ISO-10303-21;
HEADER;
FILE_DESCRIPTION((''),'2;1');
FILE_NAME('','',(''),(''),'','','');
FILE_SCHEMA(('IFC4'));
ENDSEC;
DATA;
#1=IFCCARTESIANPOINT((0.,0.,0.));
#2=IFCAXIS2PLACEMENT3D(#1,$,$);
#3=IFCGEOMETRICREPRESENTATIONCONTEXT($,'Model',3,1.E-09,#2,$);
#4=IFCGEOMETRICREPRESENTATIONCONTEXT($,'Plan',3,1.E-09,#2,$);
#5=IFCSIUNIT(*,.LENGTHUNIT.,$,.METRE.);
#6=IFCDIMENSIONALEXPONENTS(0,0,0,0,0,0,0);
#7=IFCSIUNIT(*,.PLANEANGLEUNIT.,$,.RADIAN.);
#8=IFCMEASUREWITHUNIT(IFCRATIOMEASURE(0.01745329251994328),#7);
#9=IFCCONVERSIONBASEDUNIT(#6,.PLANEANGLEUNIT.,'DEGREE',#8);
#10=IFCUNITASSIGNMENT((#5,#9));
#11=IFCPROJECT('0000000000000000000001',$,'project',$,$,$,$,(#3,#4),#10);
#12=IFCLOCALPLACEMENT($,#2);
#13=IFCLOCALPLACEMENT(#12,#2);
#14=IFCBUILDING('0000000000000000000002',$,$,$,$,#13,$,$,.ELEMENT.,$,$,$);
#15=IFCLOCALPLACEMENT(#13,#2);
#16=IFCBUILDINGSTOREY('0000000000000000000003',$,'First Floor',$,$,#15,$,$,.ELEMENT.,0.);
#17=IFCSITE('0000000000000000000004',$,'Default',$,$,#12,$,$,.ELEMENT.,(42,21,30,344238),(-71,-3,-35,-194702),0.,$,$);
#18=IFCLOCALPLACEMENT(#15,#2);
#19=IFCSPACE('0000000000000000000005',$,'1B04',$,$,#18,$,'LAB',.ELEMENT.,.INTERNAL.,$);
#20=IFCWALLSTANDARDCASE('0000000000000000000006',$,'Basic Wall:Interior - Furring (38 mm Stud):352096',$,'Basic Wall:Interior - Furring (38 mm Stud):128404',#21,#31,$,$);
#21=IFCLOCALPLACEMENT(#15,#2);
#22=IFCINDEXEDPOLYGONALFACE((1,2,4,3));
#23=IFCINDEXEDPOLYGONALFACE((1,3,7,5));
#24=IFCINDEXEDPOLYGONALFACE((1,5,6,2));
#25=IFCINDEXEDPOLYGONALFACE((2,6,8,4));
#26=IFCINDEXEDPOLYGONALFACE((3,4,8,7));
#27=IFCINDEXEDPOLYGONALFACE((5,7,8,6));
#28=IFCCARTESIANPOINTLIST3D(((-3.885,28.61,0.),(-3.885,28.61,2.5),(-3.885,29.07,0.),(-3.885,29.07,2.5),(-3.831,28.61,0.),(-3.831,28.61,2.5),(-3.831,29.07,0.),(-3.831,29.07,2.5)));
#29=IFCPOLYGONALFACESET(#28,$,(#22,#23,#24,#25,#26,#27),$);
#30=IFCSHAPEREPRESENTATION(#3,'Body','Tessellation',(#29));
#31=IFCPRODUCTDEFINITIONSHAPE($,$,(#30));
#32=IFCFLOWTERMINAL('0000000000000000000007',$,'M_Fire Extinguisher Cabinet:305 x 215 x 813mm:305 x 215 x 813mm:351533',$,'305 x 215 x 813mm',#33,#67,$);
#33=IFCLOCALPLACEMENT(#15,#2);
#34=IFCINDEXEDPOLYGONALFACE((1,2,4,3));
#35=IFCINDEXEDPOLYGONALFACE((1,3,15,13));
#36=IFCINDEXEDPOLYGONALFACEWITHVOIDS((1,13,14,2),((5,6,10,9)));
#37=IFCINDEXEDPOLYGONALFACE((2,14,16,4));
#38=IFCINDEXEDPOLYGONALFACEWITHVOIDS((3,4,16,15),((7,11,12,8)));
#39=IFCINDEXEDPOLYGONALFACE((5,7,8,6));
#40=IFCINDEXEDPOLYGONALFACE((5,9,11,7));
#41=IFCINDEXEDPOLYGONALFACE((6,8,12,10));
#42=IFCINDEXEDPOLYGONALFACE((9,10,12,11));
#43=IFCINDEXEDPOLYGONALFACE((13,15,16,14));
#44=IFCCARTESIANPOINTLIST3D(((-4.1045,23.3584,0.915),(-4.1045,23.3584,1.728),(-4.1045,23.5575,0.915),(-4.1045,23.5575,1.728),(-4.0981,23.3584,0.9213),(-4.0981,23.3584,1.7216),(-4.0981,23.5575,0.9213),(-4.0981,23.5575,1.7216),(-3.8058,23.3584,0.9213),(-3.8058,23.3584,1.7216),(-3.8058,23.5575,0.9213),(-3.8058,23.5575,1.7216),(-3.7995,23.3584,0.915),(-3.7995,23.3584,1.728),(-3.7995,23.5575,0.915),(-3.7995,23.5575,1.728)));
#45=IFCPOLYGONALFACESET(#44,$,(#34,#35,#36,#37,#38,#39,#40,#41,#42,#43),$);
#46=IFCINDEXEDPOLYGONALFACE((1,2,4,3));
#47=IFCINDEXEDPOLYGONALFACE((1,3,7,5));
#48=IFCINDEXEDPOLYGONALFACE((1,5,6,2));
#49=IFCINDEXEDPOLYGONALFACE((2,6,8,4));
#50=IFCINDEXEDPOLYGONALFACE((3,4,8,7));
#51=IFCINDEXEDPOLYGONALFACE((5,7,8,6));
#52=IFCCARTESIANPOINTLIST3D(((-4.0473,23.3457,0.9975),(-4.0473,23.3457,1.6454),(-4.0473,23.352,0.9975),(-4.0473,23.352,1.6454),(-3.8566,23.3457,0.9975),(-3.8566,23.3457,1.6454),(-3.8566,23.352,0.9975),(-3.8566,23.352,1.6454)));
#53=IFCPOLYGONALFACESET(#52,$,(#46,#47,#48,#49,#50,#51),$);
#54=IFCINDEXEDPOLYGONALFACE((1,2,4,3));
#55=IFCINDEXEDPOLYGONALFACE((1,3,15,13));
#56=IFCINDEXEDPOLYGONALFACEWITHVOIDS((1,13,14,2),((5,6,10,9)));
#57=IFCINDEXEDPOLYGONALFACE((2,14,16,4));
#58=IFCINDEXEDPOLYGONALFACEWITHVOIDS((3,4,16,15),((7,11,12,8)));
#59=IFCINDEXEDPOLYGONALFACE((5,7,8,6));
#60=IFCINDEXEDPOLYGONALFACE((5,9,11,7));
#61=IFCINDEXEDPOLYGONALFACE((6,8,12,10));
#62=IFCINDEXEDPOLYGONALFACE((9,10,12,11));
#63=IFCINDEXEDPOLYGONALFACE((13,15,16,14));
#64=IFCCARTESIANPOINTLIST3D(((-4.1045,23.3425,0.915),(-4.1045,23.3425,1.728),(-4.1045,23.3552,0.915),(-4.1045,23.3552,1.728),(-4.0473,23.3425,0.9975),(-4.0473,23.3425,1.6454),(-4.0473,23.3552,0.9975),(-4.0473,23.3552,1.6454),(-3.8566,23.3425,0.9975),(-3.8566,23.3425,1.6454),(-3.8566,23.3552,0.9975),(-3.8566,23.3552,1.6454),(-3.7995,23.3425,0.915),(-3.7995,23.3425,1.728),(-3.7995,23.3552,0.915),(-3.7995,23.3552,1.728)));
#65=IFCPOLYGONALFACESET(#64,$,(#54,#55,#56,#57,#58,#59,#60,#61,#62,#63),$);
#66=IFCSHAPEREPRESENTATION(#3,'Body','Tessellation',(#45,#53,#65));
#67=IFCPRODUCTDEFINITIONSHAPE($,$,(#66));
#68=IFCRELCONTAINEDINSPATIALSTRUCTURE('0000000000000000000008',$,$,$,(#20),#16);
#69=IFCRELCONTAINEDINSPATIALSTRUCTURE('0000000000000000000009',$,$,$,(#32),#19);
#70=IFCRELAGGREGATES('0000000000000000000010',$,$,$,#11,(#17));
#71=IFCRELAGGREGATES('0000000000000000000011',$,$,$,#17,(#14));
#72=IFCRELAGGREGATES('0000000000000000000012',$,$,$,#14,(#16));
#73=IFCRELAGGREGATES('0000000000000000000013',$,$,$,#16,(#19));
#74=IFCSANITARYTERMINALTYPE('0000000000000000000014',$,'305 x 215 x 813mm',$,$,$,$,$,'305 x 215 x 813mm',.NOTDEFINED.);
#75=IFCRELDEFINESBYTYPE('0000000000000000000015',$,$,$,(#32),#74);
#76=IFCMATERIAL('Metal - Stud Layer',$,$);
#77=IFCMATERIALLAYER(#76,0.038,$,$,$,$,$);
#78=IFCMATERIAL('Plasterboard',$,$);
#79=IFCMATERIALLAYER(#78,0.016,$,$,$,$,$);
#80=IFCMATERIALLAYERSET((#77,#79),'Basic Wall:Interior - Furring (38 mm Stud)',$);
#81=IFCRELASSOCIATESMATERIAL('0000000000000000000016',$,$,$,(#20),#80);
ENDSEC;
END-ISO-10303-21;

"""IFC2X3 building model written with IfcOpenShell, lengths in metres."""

from ifc_helpers import new_model, entity, si_unit, converted_unit, frame, frame_2d, origin, origin_2d_with_axis, place, context, project, spatial, rectangle, extrude, source, transform, mapped, material, layer, layer_set, layer_usage, type_object, type_shapes, element, save


model = new_model("IFC2X3")

# Units and contexts
model_context = context("Model", 3, precision=1e-09, world=origin())
plan_context = context("Plan", 3, precision=1e-09, world=origin())
ifc_project = project(units=[si_unit("LENGTHUNIT", "METRE"), converted_unit("PLANEANGLEUNIT", "DEGREE", entity("IfcRatioMeasure", 0.01745329251994328), si_unit("PLANEANGLEUNIT", "RADIAN"), dimensions=[0, 0, 0, 0, 0, 0, 0])], contexts=[model_context, plan_context])

# Site, building, storey
site_placement = place(None, origin())
site = spatial("IfcSite", under=ifc_project, at=site_placement, Name="Default", CompositionType="ELEMENT", RefLatitude=(42, 21, 30, 344238), RefLongitude=(-71, -3, -35, -194702), RefElevation=0.0)
building_placement = place(site_placement, origin())
building = spatial("IfcBuilding", under=site, at=building_placement, CompositionType="ELEMENT")
storey_placement = place(building_placement, origin())
storey = spatial("IfcBuildingStorey", under=building, at=storey_placement, Name="First Floor", CompositionType="ELEMENT", Elevation=0.0)

# Shared definitions
ifc_material_1 = material(Name="Plasterboard")
ifc_material_2 = material(Name="Metal - Stud Layer")

# Shared definitions
ifc_layer_1 = layer(ifc_material_2, 0.038)
ifc_layer_2 = layer(ifc_material_1, 0.016)
ifc_layer_set_1 = layer_set([ifc_layer_1, ifc_layer_2], Name="Basic Wall:Interior - Furring (38 mm Stud)")
ifc_layer_usage_1 = layer_usage(ifc_layer_set_1, "AXIS2", "POSITIVE", -0.027)

# Wall
wall_1_placement = place(storey_placement, frame((-3.858, 28.61, 0.0), z_axis=(0.0, 0.0, 1.0), x_axis=(0.0, 1.0, 0.0)))
element("IfcWallStandardCase", 1, at=wall_1_placement, inside=storey, material=ifc_layer_usage_1, Name="Basic Wall:Interior - Furring (38 mm Stud):352096", ObjectType="Basic Wall:Interior - Furring (38 mm Stud):128404", context=model_context, shape_type="SweptSolid", body=[
    extrude(rectangle(XDim=0.46, YDim=0.054, at=frame_2d((0.23, 0.0), x_axis=(-1.0, 0.0))), origin(), (0.0, 0.0, 1.0), 2.5),
])

# Shared definitions
space_placement = place(storey_placement, origin())
space = spatial("IfcSpace", under=storey, at=space_placement, Name="1B04", LongName="LAB", CompositionType="ELEMENT", InteriorOrExteriorSpace="INTERNAL")

# Flow terminal
sanitary_terminal_type = type_object("IfcSanitaryTerminalType", Name="305 x 215 x 813mm", ElementType="305 x 215 x 813mm", PredefinedType="NOTDEFINED")
cartesian_point_1 = entity("IfcCartesianPoint", [-0.1525, -0.4065])
shared_polyline = entity("IfcPolyline", [cartesian_point_1, entity("IfcCartesianPoint", [0.1525, -0.4065]), entity("IfcCartesianPoint", [0.1525, 0.4065]), entity("IfcCartesianPoint", [-0.1525, 0.4065]), cartesian_point_1])
cartesian_point_2 = entity("IfcCartesianPoint", [-0.1462, -0.4001])
cartesian_point_3 = entity("IfcCartesianPoint", [-0.0953, -0.3239])
shared_shape_1 = source(origin(), model_context, "Body", "SweptSolid", [
    entity("IfcExtrudedAreaSolid", entity("IfcArbitraryProfileDefWithVoids", "AREA", None, shared_polyline, [entity("IfcPolyline", [cartesian_point_2, entity("IfcCartesianPoint", [-0.1462, 0.4002]), entity("IfcCartesianPoint", [0.1462, 0.4002]), entity("IfcCartesianPoint", [0.1462, -0.4001]), cartesian_point_2])]), entity("IfcAxis2Placement3D", entity("IfcCartesianPoint", [-0.1096, 0.062, 1.3215]), entity("IfcDirection", [0.0, 1.0, 0.0]), entity("IfcDirection", [1.0, 0.0, 0.0])), entity("IfcDirection", [0.0, 0.0, 1.0]), 0.1991),
    extrude(rectangle(XDim=0.0064, YDim=0.1907, at=origin_2d_with_axis()), frame((-0.1096, 0.2706, 0.9975), z_axis=(0.0, 0.0, 1.0), x_axis=(0.0, -1.0, 0.0)), (0.0, 0.0, 1.0), 0.6479),
    entity("IfcExtrudedAreaSolid", entity("IfcArbitraryProfileDefWithVoids", "AREA", None, shared_polyline, [entity("IfcPolyline", [cartesian_point_3, entity("IfcCartesianPoint", [-0.0953, 0.324]), entity("IfcCartesianPoint", [0.0954, 0.324]), entity("IfcCartesianPoint", [0.0954, -0.3239]), cartesian_point_3])]), entity("IfcAxis2Placement3D", entity("IfcCartesianPoint", [-0.1096, 0.2643, 1.3215]), entity("IfcDirection", [0.0, 1.0, 0.0]), entity("IfcDirection", [1.0, 0.0, 0.0])), entity("IfcDirection", [0.0, 0.0, 1.0]), 0.0127),
])
type_shapes(sanitary_terminal_type, [shared_shape_1])
flow_terminal_placement = place(space_placement, frame((-4.0616, 23.6195, 0.0), z_axis=(0.0, 0.0, 1.0), x_axis=(-1.0, 0.0, 0.0)))
element("IfcFlowTerminal", 2, at=flow_terminal_placement, inside=space, type_object=sanitary_terminal_type, Name="M_Fire Extinguisher Cabinet:305 x 215 x 813mm:305 x 215 x 813mm:351533", ObjectType="305 x 215 x 813mm", context=model_context, shape_type="MappedRepresentation", body=[
    mapped(shared_shape_1, transform((0.0, 0.0, 0.0), scale=1.0)),
])

save(model, "model.ifc")
